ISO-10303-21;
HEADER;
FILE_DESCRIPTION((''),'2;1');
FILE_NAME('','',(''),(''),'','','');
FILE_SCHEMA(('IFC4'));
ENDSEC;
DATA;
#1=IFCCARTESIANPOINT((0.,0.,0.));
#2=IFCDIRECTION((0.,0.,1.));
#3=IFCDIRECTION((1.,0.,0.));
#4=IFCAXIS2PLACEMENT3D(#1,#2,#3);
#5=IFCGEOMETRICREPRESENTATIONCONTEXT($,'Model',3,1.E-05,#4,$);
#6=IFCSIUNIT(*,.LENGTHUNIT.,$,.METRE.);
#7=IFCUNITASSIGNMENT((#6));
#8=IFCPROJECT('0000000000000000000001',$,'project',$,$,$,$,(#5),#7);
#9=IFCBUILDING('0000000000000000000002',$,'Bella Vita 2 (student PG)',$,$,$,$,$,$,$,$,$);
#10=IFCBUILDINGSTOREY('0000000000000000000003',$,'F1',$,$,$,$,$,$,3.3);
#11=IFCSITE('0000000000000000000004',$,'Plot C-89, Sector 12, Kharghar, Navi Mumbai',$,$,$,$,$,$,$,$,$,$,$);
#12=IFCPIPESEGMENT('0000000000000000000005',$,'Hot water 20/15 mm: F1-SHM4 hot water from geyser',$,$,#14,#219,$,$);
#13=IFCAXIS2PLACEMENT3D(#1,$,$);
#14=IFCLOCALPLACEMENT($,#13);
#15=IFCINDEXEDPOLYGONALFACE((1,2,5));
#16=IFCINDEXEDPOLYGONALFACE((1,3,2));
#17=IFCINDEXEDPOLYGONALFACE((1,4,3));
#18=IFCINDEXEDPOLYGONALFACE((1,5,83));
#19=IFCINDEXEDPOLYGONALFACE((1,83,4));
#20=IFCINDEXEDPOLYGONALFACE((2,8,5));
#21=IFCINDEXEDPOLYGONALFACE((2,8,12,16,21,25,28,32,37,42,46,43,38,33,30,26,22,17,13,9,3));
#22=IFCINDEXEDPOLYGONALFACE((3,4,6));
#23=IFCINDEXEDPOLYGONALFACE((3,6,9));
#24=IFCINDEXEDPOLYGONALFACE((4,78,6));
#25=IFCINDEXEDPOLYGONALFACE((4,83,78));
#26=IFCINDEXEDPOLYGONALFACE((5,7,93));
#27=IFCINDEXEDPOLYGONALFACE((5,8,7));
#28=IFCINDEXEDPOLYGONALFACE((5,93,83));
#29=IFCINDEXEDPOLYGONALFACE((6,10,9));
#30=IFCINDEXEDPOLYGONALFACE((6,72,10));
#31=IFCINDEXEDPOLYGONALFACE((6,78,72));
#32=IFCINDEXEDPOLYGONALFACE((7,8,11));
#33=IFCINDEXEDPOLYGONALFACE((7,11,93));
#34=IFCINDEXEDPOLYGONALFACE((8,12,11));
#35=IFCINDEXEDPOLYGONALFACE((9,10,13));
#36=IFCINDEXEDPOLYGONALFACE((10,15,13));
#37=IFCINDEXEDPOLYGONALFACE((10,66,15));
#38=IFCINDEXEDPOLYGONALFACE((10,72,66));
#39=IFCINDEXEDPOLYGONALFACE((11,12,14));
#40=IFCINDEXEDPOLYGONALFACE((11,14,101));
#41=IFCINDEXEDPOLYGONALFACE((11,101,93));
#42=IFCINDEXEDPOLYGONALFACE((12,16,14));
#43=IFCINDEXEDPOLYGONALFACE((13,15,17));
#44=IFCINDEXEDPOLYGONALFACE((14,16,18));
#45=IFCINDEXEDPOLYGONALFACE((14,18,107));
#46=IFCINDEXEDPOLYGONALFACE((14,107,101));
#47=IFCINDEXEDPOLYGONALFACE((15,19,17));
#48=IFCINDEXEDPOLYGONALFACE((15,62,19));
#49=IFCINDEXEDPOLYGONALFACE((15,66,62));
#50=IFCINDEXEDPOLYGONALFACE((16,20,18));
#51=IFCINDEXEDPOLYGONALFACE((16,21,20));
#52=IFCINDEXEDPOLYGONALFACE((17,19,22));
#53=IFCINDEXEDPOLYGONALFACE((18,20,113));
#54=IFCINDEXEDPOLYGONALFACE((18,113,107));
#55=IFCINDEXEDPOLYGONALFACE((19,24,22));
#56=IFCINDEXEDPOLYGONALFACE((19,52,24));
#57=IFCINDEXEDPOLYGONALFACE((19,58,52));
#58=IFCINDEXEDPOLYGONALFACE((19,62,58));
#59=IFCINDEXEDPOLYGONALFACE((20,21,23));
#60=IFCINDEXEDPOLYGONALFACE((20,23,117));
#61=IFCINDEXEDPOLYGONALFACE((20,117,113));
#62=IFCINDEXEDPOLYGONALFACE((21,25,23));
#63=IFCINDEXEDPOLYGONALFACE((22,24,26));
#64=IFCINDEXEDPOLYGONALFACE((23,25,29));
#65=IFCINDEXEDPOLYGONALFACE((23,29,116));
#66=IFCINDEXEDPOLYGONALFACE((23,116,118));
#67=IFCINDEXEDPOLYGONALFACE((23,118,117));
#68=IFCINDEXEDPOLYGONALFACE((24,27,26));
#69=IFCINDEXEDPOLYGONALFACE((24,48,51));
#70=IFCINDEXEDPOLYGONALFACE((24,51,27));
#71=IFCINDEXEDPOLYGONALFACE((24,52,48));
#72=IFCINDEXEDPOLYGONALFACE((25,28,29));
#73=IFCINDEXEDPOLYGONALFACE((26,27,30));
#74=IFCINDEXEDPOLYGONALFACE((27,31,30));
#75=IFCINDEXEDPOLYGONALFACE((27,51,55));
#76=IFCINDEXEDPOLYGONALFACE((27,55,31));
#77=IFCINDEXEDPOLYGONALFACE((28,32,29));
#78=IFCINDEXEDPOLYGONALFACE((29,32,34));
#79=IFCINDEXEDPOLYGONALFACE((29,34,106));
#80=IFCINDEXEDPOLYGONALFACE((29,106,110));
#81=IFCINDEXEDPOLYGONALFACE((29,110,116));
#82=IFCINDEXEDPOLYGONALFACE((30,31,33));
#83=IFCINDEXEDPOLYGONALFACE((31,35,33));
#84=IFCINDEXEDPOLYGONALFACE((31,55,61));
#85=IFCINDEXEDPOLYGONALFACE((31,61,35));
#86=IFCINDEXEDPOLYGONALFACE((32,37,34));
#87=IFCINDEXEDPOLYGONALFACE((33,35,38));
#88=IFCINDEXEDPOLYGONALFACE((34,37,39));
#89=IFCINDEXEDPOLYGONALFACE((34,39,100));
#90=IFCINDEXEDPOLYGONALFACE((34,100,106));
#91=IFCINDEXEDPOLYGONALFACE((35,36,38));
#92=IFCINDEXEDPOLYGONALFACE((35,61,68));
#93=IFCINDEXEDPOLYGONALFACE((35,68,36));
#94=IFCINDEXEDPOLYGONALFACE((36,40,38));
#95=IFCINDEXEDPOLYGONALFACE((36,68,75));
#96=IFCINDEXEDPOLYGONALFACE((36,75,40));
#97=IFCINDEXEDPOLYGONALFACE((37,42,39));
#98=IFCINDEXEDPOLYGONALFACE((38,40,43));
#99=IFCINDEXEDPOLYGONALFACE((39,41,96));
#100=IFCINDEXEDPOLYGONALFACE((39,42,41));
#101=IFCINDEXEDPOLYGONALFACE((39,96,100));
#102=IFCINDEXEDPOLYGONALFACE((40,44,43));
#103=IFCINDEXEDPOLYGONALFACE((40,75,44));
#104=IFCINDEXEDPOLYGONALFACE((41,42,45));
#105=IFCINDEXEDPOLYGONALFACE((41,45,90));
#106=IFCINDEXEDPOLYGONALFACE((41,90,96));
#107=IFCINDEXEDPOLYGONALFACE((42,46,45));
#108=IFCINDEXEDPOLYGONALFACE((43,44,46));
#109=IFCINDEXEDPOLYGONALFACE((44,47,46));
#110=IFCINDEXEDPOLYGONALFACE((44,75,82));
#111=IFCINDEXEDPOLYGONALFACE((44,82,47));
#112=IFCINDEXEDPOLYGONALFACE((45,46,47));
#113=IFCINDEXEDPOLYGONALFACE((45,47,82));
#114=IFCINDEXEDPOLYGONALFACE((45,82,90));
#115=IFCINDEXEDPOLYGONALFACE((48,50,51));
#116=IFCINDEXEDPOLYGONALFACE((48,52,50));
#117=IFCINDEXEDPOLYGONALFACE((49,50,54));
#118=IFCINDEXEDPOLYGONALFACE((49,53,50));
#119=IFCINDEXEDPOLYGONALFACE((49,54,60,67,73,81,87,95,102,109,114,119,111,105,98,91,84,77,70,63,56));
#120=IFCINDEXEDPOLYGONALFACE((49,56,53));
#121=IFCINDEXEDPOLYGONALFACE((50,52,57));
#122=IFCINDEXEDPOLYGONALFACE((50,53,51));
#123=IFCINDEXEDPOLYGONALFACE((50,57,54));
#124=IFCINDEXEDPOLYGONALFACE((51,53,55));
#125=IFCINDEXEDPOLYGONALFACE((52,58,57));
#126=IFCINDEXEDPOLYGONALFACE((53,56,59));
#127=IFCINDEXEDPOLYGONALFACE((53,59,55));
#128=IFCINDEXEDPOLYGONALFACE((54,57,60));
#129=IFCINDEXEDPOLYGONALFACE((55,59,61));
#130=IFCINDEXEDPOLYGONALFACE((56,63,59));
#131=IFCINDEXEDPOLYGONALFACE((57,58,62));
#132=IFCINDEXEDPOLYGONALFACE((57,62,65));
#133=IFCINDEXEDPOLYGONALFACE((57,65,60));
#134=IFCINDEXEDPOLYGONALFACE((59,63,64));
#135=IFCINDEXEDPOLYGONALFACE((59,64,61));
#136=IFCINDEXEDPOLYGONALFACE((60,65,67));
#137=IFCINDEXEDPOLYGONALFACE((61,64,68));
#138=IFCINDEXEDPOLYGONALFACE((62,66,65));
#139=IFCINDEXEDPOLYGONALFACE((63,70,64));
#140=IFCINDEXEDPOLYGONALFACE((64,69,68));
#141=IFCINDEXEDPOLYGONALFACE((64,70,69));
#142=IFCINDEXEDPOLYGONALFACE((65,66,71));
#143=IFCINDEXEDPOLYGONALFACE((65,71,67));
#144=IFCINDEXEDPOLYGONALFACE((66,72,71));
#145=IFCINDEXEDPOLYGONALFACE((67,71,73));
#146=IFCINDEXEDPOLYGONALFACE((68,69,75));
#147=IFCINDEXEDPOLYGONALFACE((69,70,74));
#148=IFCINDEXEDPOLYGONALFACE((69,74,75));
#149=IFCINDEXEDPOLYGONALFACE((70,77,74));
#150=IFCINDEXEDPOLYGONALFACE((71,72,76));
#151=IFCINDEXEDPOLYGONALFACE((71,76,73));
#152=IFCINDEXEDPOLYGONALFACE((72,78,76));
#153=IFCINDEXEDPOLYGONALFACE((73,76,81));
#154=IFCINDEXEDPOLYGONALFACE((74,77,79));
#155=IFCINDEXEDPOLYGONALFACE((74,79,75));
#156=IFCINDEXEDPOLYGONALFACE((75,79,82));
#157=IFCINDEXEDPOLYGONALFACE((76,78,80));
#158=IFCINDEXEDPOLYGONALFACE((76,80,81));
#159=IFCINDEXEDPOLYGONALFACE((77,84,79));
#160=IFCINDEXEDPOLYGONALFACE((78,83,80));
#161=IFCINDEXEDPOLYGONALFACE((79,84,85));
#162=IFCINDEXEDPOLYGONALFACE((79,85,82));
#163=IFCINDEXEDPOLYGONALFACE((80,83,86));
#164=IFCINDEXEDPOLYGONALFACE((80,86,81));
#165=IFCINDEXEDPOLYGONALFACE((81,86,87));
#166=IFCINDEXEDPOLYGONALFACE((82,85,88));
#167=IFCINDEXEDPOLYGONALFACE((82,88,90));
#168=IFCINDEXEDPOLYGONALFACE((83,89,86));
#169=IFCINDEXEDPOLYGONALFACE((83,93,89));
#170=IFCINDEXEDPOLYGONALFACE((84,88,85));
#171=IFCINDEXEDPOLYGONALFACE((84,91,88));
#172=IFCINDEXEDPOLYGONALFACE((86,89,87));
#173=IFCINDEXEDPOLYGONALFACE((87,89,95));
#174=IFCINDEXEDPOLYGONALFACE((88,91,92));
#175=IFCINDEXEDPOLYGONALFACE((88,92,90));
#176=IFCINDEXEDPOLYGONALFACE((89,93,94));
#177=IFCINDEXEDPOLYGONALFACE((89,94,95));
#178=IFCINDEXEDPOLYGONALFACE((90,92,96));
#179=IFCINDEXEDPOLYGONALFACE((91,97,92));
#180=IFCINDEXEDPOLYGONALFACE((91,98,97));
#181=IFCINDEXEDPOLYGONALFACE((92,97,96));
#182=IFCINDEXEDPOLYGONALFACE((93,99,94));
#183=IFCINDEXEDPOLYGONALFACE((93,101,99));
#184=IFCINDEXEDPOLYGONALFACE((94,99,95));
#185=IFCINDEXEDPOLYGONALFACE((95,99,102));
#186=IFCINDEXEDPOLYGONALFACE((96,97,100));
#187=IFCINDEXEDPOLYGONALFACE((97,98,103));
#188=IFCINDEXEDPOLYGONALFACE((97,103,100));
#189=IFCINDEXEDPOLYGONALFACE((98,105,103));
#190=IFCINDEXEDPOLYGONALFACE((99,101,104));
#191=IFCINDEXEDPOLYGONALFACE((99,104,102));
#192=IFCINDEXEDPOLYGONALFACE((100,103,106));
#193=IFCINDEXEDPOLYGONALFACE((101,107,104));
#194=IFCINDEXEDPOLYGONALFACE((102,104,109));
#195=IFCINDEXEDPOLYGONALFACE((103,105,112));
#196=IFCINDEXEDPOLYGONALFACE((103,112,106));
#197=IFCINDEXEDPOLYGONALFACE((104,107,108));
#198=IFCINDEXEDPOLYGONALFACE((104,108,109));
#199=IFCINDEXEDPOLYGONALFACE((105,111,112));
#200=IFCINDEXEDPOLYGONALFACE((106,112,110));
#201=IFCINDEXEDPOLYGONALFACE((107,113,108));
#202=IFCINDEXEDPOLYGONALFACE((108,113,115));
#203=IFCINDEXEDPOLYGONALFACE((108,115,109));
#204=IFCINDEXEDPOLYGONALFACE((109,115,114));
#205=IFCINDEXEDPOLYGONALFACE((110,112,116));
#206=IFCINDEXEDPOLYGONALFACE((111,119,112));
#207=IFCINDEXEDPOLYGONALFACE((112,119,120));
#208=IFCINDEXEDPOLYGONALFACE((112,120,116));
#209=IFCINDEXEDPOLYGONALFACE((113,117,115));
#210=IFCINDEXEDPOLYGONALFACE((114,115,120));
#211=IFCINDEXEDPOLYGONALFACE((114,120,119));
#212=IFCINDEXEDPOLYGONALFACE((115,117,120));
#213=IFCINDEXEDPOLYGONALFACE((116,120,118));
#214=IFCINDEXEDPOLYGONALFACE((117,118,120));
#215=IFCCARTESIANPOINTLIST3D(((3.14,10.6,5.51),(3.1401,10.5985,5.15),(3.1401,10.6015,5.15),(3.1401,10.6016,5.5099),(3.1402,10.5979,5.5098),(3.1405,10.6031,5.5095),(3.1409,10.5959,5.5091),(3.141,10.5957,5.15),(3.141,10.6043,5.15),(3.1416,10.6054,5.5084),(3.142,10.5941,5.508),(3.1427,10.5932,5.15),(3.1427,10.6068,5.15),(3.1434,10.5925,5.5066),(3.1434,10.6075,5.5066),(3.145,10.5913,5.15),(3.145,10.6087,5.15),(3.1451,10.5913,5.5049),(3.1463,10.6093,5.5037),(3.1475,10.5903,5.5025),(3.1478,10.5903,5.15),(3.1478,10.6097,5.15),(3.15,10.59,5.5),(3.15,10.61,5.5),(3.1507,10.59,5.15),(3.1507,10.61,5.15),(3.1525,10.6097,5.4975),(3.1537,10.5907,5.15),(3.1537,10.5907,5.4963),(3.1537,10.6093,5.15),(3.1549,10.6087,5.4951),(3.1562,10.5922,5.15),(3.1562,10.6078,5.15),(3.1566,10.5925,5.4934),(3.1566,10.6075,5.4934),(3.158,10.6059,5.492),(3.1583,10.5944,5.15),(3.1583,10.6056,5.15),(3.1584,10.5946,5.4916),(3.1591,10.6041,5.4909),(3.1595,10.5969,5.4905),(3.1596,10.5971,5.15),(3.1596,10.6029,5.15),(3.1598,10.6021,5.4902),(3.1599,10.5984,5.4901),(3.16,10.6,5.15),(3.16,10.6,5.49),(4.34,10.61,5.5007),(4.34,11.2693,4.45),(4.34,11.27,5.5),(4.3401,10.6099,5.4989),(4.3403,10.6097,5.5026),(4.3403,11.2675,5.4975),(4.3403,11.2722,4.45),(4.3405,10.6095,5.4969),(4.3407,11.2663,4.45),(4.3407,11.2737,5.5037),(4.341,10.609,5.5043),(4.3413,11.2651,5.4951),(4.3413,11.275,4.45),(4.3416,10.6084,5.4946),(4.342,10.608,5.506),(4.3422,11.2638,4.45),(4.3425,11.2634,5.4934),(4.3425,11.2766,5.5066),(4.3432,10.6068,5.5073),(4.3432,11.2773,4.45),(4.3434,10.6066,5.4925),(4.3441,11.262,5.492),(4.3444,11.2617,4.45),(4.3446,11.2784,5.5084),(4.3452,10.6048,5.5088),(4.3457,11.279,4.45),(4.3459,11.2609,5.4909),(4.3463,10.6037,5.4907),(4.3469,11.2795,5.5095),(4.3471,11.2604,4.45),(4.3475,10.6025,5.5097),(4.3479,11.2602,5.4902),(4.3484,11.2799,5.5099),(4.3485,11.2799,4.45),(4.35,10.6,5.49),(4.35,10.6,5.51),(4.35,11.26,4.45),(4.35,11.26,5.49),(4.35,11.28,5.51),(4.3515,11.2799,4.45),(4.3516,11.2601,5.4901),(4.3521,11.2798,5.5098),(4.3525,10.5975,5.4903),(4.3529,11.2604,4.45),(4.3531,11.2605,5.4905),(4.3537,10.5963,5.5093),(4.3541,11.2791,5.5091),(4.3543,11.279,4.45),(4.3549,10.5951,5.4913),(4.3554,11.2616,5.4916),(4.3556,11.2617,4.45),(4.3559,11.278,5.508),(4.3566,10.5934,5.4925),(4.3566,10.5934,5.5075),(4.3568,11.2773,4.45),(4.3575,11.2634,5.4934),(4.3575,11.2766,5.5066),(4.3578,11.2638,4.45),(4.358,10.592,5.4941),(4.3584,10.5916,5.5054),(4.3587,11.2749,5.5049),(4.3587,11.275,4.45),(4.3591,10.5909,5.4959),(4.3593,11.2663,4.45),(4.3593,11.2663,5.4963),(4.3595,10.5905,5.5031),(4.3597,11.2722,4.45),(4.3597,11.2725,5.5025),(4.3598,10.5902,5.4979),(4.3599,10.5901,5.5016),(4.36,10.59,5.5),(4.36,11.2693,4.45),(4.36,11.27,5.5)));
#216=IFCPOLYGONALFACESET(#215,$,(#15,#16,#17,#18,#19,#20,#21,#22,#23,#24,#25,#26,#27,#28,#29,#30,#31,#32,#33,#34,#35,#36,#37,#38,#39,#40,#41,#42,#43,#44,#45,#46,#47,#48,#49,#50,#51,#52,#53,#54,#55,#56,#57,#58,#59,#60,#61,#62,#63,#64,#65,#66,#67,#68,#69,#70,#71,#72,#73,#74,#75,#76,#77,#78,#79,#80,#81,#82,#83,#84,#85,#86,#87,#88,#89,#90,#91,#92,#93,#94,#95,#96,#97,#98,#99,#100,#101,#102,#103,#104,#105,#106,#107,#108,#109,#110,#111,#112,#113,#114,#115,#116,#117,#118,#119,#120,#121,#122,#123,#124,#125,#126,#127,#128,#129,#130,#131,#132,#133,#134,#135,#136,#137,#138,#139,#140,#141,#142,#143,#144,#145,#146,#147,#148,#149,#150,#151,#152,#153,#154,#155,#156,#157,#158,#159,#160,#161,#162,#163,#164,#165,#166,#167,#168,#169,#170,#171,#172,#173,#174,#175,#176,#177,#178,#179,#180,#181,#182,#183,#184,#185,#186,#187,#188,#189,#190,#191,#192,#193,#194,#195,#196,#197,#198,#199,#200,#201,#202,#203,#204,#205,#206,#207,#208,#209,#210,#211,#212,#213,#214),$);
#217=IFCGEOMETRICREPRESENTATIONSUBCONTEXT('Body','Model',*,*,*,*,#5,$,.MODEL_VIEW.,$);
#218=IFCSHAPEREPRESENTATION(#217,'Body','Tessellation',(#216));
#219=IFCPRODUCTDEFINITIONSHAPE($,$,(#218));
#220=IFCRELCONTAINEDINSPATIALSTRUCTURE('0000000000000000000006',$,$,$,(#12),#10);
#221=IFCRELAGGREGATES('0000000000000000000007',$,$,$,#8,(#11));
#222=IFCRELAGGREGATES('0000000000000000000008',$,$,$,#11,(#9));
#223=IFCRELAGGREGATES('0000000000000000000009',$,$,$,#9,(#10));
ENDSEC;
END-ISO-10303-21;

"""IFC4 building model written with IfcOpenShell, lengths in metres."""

from ifc_helpers import new_model, entity, si_unit, origin, origin_with_axes, place, context, subcontext, project, spatial, element, save


model = new_model("IFC4")

# Units and contexts
model_context = context("Model", 3, precision=1e-05, world=origin_with_axes())
body_context = subcontext(model_context, "Body", "Model", "MODEL_VIEW")
ifc_project = project(units=[si_unit("LENGTHUNIT", "METRE")], contexts=[model_context])

# Site, building, storey
site = spatial("IfcSite", under=ifc_project, Name="Plot C-89, Sector 12, Kharghar, Navi Mumbai")
building = spatial("IfcBuilding", under=site, Name="Bella Vita 2 (student PG)")
storey = spatial("IfcBuildingStorey", under=building, Name="F1", Elevation=3.3)

# Pipe segment
pipe_segment_1_placement = place(None, origin())
element("IfcPipeSegment", 1, at=pipe_segment_1_placement, inside=storey, Name="Hot water 20/15 mm: F1-SHM4 hot water from geyser", context=body_context, shape_type="AdvancedSweptSolid", body=[
    entity("IfcSweptDiskSolid", entity("IfcPolyline", [entity("IfcCartesianPoint", [3.15, 10.6, 5.15]), entity("IfcCartesianPoint", [3.15, 10.6, 5.5]), entity("IfcCartesianPoint", [4.35, 10.6, 5.5]), entity("IfcCartesianPoint", [4.35, 11.27, 5.5]), entity("IfcCartesianPoint", [4.35, 11.27, 4.45])]), 0.01),
])

save(model, "model.ifc")
